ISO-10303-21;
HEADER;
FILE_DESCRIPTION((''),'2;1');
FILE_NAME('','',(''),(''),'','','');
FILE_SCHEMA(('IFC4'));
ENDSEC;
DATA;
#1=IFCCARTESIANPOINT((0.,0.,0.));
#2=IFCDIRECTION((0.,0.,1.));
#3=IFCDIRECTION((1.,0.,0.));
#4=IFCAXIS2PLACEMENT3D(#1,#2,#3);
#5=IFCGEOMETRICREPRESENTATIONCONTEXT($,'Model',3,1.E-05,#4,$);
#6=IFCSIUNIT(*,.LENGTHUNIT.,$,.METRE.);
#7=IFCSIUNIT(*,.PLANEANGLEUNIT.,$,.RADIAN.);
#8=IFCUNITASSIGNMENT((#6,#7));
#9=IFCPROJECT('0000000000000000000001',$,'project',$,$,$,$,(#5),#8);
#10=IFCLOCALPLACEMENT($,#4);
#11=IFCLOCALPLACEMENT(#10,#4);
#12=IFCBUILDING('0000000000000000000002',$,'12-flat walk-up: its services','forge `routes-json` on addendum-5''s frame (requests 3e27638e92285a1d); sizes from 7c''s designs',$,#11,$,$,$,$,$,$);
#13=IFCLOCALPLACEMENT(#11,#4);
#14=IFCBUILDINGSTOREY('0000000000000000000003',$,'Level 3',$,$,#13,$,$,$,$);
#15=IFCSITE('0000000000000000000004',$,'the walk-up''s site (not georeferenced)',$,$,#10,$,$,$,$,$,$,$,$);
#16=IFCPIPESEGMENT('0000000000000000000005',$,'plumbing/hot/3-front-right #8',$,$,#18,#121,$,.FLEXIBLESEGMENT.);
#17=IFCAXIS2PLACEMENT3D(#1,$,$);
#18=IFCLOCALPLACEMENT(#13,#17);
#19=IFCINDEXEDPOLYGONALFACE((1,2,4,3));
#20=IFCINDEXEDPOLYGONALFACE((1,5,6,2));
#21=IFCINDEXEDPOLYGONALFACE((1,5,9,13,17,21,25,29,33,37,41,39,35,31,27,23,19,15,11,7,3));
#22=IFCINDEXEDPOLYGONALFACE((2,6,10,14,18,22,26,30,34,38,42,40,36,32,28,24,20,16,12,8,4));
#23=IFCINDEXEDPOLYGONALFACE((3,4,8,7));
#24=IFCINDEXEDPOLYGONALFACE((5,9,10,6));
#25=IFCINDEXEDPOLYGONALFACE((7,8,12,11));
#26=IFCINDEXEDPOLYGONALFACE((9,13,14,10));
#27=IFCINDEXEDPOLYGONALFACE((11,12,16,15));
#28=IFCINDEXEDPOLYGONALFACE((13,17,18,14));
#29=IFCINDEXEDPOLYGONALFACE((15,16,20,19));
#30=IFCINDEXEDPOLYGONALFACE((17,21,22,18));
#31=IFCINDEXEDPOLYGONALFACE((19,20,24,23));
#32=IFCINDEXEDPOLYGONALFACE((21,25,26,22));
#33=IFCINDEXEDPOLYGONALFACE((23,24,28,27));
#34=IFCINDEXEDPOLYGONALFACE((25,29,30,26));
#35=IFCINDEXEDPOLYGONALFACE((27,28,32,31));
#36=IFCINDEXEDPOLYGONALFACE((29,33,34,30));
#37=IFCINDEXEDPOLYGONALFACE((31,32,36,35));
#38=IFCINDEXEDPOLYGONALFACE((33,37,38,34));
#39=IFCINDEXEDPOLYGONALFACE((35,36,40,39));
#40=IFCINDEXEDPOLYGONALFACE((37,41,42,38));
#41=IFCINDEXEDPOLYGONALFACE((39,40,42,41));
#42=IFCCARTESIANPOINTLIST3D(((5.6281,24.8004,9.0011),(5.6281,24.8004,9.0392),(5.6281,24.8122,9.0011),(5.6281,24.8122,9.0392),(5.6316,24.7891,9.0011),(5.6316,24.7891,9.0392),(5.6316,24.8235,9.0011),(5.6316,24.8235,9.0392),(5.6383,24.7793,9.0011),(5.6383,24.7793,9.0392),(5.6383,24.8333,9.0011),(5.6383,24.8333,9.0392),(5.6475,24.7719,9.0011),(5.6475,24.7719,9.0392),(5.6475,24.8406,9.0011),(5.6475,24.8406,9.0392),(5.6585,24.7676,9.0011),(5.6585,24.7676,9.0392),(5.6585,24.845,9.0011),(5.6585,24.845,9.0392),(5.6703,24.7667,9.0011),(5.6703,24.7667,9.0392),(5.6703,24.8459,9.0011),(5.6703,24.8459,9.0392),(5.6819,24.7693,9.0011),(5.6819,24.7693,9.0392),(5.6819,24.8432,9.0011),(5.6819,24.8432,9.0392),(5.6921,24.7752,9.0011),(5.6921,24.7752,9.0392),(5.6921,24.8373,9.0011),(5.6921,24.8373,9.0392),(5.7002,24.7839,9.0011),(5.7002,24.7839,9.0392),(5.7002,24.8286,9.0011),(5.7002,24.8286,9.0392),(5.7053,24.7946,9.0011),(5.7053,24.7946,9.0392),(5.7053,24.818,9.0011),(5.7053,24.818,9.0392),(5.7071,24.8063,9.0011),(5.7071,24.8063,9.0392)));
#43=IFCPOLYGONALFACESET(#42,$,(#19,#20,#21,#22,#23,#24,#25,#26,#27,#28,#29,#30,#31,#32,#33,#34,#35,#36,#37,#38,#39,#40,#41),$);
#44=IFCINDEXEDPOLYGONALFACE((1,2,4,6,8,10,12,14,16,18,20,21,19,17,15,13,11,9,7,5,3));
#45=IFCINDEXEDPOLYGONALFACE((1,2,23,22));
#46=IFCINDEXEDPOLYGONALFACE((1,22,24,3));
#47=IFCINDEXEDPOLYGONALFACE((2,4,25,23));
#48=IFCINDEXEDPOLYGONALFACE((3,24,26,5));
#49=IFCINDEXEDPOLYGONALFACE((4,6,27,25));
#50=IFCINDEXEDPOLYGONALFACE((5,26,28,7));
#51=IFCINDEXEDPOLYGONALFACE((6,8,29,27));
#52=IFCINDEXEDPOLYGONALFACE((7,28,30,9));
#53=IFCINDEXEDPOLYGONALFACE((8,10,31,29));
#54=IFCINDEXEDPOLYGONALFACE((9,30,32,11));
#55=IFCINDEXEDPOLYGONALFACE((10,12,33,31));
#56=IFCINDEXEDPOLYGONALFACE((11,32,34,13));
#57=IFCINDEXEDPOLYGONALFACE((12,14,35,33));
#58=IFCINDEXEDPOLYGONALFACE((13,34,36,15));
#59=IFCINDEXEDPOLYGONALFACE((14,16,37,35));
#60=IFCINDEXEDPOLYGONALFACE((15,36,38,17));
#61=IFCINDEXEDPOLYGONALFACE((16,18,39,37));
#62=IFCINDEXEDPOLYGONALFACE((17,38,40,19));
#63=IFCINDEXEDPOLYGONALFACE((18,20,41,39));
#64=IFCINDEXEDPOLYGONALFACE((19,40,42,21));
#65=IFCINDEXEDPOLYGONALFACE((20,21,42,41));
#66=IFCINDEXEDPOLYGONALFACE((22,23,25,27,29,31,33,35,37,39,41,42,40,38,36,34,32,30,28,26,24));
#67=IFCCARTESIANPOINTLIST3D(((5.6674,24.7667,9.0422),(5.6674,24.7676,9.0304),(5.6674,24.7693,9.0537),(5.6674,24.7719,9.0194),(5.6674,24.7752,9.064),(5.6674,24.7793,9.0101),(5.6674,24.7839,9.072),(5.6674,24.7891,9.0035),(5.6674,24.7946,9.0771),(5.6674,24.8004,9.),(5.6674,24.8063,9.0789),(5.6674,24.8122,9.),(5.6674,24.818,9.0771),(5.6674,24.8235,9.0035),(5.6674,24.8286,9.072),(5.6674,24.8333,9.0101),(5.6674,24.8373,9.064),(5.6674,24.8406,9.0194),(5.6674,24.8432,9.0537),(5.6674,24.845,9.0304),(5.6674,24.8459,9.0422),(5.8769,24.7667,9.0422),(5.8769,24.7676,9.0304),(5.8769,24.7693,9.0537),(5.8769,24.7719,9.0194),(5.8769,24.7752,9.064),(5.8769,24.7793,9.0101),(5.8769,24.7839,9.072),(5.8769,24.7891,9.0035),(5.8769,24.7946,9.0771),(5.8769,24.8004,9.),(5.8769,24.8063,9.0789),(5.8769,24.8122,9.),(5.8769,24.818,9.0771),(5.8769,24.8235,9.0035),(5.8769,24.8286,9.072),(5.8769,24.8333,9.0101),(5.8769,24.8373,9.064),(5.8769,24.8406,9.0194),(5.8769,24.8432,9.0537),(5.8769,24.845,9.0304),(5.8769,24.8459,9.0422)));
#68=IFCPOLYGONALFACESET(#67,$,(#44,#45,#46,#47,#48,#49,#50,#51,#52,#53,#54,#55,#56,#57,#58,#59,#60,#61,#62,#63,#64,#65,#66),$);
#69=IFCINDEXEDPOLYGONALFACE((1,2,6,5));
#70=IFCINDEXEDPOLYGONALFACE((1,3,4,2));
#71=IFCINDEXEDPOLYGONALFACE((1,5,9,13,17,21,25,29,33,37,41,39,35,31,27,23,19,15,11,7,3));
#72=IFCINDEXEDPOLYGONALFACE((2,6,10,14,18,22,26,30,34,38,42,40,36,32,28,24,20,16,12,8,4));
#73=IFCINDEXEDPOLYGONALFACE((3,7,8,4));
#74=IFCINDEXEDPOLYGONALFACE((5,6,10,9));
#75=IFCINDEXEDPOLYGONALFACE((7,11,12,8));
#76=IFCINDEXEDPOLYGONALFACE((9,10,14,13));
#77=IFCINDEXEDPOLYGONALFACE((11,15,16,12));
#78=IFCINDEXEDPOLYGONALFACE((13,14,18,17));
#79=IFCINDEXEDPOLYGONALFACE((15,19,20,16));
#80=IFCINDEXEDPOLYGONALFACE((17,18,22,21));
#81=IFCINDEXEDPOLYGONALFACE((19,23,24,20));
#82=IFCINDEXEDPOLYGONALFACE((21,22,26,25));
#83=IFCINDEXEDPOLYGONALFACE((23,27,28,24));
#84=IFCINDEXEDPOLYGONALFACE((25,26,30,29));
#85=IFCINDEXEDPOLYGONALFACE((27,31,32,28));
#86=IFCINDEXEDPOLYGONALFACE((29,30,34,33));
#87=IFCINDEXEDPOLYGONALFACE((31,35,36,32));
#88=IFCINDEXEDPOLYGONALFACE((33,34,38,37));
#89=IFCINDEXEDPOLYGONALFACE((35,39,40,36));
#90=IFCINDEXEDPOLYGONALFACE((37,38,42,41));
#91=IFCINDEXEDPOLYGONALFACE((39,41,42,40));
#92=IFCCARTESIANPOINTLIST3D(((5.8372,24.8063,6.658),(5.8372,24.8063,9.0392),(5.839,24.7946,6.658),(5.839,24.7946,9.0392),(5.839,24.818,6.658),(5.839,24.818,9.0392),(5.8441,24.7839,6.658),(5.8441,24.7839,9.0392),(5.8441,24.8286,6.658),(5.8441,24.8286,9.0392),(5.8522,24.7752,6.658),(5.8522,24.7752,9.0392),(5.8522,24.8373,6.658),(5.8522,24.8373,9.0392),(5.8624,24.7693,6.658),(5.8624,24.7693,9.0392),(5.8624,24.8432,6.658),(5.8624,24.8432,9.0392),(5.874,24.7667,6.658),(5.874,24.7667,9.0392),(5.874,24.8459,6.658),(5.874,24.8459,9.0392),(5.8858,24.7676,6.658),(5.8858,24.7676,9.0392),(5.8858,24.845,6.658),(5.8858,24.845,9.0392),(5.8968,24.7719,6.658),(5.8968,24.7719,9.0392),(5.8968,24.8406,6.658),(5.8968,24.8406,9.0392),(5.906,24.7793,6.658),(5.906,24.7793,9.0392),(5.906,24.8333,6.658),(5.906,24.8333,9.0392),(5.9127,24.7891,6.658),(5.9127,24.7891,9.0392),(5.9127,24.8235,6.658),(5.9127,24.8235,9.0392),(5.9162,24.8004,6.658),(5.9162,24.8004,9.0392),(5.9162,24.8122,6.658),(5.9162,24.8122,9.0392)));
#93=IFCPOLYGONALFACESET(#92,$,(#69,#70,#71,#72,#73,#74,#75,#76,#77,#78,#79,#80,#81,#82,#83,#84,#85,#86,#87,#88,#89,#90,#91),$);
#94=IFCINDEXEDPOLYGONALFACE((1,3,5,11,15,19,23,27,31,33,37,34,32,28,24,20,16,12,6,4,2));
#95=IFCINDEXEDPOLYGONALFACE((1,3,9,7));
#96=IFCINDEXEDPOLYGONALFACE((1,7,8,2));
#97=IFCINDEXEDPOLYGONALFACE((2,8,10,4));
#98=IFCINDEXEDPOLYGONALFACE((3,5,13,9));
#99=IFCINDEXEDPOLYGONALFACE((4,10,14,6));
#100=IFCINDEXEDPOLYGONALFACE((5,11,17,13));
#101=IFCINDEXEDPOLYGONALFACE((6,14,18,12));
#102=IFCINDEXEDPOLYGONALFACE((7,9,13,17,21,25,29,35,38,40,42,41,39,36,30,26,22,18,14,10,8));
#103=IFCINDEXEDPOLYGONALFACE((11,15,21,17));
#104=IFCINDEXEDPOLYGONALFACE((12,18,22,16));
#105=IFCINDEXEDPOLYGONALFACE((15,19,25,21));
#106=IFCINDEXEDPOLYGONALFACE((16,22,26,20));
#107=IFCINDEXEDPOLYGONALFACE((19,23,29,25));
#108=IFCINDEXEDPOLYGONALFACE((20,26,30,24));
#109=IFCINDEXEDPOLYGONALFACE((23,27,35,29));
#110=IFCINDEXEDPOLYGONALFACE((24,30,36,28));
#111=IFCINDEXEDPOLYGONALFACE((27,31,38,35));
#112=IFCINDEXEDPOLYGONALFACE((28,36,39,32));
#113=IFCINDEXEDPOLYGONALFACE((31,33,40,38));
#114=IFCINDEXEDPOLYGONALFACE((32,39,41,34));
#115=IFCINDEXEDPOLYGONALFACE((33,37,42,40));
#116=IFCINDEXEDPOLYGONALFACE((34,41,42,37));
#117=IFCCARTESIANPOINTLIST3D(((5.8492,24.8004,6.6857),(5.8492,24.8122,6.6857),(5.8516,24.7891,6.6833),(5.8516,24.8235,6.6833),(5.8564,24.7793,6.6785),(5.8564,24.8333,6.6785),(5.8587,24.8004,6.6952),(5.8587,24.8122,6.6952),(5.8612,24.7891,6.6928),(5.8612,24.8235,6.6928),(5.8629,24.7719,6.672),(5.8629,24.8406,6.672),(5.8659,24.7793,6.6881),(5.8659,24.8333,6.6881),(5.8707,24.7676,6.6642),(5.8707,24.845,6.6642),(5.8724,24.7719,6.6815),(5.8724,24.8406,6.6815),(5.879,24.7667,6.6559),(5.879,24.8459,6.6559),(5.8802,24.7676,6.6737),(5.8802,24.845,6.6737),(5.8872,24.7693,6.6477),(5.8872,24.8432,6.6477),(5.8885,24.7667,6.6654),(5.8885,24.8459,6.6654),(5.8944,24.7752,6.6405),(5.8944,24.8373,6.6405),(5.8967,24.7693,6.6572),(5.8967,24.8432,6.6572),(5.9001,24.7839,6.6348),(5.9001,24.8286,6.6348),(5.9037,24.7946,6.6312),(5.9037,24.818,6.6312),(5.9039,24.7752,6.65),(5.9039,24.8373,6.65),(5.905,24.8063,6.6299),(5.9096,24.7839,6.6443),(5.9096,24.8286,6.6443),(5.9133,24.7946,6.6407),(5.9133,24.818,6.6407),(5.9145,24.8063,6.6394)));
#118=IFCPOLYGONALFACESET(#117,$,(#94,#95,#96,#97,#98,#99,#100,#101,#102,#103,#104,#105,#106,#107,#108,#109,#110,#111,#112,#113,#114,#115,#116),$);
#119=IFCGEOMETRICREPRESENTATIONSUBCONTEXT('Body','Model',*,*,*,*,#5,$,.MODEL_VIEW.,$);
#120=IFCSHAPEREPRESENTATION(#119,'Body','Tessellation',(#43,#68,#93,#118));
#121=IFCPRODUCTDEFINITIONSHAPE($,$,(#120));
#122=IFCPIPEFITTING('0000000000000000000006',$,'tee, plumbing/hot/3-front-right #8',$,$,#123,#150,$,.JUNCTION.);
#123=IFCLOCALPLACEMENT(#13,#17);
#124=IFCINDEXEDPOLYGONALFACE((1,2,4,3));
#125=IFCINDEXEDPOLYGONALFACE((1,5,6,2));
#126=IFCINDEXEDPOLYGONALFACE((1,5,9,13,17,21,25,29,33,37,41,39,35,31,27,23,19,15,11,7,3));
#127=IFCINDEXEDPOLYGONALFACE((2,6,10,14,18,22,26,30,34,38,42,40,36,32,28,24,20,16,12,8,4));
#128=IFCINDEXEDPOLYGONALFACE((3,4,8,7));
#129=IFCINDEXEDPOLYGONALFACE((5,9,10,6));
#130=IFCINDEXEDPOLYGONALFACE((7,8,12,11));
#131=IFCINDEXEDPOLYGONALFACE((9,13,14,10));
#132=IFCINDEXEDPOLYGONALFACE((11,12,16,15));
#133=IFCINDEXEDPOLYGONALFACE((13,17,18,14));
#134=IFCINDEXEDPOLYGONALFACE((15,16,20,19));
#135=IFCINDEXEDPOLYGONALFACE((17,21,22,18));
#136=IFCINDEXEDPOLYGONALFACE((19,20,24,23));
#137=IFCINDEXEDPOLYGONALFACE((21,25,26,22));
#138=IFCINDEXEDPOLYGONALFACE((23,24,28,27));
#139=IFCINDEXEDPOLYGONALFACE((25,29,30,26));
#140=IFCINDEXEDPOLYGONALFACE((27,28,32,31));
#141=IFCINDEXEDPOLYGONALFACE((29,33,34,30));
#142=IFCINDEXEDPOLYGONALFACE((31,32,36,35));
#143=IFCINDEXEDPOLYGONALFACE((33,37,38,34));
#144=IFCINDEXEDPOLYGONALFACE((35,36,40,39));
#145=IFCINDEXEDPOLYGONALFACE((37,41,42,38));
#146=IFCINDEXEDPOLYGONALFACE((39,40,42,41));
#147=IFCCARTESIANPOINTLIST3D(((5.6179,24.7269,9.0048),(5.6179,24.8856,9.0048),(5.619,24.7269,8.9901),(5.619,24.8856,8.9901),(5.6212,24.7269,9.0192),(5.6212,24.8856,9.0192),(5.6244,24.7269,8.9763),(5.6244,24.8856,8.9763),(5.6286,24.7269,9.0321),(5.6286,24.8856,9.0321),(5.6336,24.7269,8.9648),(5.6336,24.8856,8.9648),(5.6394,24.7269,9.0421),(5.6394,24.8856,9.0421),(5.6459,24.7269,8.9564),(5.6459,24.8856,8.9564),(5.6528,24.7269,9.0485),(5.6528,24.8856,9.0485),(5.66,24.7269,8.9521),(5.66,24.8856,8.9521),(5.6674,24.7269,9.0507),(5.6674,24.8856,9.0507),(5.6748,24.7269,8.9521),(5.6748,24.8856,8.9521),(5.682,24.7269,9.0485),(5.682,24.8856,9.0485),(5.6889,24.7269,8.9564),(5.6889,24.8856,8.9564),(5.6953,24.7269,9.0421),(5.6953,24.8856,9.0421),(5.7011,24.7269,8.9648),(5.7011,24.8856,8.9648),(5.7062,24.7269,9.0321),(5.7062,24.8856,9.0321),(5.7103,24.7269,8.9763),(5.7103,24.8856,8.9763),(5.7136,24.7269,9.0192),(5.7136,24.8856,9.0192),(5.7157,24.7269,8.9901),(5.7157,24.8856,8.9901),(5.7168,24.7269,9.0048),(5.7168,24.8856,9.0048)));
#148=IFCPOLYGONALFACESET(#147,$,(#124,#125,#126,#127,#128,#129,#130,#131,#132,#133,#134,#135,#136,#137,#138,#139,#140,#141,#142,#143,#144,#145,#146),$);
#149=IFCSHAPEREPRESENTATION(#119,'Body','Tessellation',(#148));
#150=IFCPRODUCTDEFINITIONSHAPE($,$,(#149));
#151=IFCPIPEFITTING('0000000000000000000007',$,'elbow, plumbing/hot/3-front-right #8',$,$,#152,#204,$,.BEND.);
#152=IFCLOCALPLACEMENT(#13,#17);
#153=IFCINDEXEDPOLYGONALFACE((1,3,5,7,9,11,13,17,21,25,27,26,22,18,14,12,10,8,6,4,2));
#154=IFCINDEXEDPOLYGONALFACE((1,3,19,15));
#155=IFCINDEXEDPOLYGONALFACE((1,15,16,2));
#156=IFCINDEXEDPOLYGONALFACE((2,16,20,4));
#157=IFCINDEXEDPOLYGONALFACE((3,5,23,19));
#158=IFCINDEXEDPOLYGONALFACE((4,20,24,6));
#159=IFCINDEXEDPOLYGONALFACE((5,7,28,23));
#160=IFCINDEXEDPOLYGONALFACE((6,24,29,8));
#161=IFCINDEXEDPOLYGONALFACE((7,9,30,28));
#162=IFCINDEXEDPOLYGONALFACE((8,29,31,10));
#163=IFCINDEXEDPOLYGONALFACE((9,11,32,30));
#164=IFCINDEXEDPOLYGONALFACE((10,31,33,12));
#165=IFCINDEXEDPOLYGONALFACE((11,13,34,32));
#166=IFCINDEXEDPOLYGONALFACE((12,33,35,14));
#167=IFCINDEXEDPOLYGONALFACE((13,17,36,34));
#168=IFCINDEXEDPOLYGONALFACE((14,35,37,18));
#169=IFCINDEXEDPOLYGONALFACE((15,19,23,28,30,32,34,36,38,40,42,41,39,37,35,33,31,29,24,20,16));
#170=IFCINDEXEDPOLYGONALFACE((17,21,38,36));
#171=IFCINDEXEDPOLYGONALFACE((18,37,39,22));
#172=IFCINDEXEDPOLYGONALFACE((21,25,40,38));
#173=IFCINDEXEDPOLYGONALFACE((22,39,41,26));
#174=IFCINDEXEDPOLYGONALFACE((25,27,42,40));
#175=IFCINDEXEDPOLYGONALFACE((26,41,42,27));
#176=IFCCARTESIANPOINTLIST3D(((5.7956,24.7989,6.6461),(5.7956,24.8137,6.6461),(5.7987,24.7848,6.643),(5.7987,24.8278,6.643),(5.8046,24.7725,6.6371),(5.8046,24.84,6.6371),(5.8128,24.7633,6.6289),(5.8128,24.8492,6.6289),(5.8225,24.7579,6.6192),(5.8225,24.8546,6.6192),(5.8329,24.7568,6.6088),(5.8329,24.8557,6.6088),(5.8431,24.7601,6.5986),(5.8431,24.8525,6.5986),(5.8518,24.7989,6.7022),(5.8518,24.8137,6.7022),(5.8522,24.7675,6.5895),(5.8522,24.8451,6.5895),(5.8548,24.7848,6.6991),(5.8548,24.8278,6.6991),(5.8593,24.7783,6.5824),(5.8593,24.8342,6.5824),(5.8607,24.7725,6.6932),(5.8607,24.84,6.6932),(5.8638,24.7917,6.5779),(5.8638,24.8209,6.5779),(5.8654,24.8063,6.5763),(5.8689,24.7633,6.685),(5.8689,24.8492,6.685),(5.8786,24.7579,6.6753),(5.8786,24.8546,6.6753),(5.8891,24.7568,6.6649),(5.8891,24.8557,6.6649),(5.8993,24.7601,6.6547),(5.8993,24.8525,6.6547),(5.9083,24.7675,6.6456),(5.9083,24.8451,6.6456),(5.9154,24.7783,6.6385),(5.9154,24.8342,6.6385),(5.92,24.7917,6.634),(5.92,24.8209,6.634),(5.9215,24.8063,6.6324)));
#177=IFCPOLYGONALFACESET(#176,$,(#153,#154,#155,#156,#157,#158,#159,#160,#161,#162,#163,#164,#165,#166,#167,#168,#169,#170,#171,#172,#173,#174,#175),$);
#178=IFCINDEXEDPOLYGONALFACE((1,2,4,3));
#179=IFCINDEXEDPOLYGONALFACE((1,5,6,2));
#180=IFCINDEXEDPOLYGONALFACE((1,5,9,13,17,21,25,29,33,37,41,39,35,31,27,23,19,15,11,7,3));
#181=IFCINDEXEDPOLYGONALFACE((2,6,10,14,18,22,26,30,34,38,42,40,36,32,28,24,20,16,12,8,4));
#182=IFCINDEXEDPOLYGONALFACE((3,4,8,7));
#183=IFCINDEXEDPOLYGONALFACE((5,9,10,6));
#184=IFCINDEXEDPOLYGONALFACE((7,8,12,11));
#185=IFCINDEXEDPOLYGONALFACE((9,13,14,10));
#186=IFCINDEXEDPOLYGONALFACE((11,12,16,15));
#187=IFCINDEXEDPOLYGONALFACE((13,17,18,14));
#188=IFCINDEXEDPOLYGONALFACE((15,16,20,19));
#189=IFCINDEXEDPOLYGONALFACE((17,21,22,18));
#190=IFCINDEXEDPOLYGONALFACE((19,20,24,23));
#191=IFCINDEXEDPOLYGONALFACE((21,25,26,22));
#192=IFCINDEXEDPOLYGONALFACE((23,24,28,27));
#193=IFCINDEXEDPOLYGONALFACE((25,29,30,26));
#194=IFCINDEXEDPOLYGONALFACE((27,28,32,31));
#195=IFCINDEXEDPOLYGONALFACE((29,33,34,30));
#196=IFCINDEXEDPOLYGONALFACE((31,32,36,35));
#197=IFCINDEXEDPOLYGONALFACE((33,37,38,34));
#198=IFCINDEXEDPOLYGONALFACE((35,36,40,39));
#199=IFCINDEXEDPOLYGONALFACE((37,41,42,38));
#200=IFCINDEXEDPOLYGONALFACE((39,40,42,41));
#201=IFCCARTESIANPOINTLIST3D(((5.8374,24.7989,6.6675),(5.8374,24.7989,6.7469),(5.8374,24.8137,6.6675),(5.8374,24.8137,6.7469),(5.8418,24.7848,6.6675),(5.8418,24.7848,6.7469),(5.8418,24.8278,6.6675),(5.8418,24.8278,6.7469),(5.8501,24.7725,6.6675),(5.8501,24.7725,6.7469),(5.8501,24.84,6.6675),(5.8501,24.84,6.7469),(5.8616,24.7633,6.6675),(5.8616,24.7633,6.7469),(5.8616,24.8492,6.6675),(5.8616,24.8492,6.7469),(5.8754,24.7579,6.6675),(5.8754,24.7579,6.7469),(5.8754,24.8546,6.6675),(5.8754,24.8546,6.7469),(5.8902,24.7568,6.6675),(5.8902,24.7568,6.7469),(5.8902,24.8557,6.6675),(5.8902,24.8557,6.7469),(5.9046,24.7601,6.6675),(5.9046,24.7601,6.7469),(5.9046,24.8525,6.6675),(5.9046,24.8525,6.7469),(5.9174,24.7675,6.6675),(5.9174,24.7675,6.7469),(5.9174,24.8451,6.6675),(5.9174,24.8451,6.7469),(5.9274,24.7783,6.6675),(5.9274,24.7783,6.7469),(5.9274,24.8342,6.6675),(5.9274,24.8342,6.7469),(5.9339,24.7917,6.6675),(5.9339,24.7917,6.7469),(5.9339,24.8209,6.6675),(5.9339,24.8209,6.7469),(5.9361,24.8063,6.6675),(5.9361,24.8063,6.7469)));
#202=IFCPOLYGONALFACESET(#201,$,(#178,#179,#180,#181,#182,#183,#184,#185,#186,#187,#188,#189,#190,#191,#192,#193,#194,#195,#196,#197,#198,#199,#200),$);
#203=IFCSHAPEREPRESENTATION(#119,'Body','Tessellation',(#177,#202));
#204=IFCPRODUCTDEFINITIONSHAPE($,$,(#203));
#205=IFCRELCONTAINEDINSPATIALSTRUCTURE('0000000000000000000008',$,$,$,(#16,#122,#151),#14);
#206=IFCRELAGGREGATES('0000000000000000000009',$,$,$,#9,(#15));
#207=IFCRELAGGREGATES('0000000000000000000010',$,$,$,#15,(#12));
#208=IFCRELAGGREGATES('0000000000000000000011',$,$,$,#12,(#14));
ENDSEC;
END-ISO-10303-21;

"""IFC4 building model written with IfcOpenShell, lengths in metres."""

from ifc_helpers import new_model, entity, si_unit, frame, origin_with_axes, place, context, subcontext, project, spatial, element, save


model = new_model("IFC4")

# Units and contexts
model_context = context("Model", 3, precision=1e-05, world=origin_with_axes())
body_context = subcontext(model_context, "Body", "Model", "MODEL_VIEW")
ifc_project = project(units=[si_unit("LENGTHUNIT", "METRE"), si_unit("PLANEANGLEUNIT", "RADIAN")], contexts=[model_context])

# Site, building, storey
site_placement = place(None, origin_with_axes())
site = spatial("IfcSite", under=ifc_project, at=site_placement, Name="the walk-up's site (not georeferenced)")
building_placement = place(site_placement, origin_with_axes())
building = spatial("IfcBuilding", under=site, at=building_placement, Name="12-flat walk-up: its services", Description="forge `routes-json` on addendum-5's frame (requests 3e27638e92285a1d); sizes from 7c's designs")
storey_placement = place(building_placement, origin_with_axes())
storey = spatial("IfcBuildingStorey", under=building, at=storey_placement, Name="Level 3")

# Pipe segment
pipe_segment_1_placement = place(storey_placement, frame((5.6674, 24.8063, 9.0011), z_axis=(0.0, 0.0, 1.0), x_axis=(1.0, 0.0, 0.0)))
element("IfcPipeSegment", 1, at=pipe_segment_1_placement, inside=storey, Name="plumbing/hot/3-front-right #8", PredefinedType="FLEXIBLESEGMENT", context=body_context, shape_type="AdvancedSweptSolid", body=[
    entity("IfcSweptDiskSolid", entity("IfcPolyline", [entity("IfcCartesianPoint", [0.0, 0.0, 0.0]), entity("IfcCartesianPoint", [0.0, 0.0, 0.0381])]), 0.0397),
    entity("IfcSweptDiskSolid", entity("IfcPolyline", [entity("IfcCartesianPoint", [0.0, 0.0, 0.0381]), entity("IfcCartesianPoint", [0.2096, 0.0, 0.0381])]), 0.0397),
    entity("IfcSweptDiskSolid", entity("IfcPolyline", [entity("IfcCartesianPoint", [0.2096, 0.0, 0.0381]), entity("IfcCartesianPoint", [0.2096, 0.0, -2.3431])]), 0.0397),
    entity("IfcSweptDiskSolid", entity("IfcPolyline", [entity("IfcCartesianPoint", [0.2096, 0.0, -2.3431]), entity("IfcCartesianPoint", [0.2191, 0.0, -2.3336])]), 0.0397),
])

# Pipe fittings
pipe_fitting_1_placement = place(storey_placement, frame((5.6674, 24.7269, 9.0011), z_axis=(0.0, 0.0, 1.0), x_axis=(1.0, 0.0, 0.0)))
element("IfcPipeFitting", 2, at=pipe_fitting_1_placement, inside=storey, Name="tee, plumbing/hot/3-front-right #8", PredefinedType="JUNCTION", context=body_context, shape_type="AdvancedSweptSolid", body=[
    entity("IfcSweptDiskSolid", entity("IfcPolyline", [entity("IfcCartesianPoint", [0.0, 0.0, 0.0]), entity("IfcCartesianPoint", [0.0, 0.1587, 0.0])]), 0.0496),
])
pipe_fitting_2_placement = place(storey_placement, frame((5.8303, 24.8063, 6.6114), z_axis=(0.0, 0.0, 1.0), x_axis=(1.0, 0.0, 0.0)))
element("IfcPipeFitting", 3, at=pipe_fitting_2_placement, inside=storey, Name="elbow, plumbing/hot/3-front-right #8", PredefinedType="BEND", context=body_context, shape_type="AdvancedSweptSolid", body=[
    entity("IfcSweptDiskSolid", entity("IfcPolyline", [entity("IfcCartesianPoint", [0.0, 0.0, 0.0]), entity("IfcCartesianPoint", [0.0561, 0.0, 0.0561])]), 0.0496),
    entity("IfcSweptDiskSolid", entity("IfcPolyline", [entity("IfcCartesianPoint", [0.0561, 0.0, 0.0561]), entity("IfcCartesianPoint", [0.0561, 0.0, 0.1355])]), 0.0496),
])

save(model, "model.ifc")
